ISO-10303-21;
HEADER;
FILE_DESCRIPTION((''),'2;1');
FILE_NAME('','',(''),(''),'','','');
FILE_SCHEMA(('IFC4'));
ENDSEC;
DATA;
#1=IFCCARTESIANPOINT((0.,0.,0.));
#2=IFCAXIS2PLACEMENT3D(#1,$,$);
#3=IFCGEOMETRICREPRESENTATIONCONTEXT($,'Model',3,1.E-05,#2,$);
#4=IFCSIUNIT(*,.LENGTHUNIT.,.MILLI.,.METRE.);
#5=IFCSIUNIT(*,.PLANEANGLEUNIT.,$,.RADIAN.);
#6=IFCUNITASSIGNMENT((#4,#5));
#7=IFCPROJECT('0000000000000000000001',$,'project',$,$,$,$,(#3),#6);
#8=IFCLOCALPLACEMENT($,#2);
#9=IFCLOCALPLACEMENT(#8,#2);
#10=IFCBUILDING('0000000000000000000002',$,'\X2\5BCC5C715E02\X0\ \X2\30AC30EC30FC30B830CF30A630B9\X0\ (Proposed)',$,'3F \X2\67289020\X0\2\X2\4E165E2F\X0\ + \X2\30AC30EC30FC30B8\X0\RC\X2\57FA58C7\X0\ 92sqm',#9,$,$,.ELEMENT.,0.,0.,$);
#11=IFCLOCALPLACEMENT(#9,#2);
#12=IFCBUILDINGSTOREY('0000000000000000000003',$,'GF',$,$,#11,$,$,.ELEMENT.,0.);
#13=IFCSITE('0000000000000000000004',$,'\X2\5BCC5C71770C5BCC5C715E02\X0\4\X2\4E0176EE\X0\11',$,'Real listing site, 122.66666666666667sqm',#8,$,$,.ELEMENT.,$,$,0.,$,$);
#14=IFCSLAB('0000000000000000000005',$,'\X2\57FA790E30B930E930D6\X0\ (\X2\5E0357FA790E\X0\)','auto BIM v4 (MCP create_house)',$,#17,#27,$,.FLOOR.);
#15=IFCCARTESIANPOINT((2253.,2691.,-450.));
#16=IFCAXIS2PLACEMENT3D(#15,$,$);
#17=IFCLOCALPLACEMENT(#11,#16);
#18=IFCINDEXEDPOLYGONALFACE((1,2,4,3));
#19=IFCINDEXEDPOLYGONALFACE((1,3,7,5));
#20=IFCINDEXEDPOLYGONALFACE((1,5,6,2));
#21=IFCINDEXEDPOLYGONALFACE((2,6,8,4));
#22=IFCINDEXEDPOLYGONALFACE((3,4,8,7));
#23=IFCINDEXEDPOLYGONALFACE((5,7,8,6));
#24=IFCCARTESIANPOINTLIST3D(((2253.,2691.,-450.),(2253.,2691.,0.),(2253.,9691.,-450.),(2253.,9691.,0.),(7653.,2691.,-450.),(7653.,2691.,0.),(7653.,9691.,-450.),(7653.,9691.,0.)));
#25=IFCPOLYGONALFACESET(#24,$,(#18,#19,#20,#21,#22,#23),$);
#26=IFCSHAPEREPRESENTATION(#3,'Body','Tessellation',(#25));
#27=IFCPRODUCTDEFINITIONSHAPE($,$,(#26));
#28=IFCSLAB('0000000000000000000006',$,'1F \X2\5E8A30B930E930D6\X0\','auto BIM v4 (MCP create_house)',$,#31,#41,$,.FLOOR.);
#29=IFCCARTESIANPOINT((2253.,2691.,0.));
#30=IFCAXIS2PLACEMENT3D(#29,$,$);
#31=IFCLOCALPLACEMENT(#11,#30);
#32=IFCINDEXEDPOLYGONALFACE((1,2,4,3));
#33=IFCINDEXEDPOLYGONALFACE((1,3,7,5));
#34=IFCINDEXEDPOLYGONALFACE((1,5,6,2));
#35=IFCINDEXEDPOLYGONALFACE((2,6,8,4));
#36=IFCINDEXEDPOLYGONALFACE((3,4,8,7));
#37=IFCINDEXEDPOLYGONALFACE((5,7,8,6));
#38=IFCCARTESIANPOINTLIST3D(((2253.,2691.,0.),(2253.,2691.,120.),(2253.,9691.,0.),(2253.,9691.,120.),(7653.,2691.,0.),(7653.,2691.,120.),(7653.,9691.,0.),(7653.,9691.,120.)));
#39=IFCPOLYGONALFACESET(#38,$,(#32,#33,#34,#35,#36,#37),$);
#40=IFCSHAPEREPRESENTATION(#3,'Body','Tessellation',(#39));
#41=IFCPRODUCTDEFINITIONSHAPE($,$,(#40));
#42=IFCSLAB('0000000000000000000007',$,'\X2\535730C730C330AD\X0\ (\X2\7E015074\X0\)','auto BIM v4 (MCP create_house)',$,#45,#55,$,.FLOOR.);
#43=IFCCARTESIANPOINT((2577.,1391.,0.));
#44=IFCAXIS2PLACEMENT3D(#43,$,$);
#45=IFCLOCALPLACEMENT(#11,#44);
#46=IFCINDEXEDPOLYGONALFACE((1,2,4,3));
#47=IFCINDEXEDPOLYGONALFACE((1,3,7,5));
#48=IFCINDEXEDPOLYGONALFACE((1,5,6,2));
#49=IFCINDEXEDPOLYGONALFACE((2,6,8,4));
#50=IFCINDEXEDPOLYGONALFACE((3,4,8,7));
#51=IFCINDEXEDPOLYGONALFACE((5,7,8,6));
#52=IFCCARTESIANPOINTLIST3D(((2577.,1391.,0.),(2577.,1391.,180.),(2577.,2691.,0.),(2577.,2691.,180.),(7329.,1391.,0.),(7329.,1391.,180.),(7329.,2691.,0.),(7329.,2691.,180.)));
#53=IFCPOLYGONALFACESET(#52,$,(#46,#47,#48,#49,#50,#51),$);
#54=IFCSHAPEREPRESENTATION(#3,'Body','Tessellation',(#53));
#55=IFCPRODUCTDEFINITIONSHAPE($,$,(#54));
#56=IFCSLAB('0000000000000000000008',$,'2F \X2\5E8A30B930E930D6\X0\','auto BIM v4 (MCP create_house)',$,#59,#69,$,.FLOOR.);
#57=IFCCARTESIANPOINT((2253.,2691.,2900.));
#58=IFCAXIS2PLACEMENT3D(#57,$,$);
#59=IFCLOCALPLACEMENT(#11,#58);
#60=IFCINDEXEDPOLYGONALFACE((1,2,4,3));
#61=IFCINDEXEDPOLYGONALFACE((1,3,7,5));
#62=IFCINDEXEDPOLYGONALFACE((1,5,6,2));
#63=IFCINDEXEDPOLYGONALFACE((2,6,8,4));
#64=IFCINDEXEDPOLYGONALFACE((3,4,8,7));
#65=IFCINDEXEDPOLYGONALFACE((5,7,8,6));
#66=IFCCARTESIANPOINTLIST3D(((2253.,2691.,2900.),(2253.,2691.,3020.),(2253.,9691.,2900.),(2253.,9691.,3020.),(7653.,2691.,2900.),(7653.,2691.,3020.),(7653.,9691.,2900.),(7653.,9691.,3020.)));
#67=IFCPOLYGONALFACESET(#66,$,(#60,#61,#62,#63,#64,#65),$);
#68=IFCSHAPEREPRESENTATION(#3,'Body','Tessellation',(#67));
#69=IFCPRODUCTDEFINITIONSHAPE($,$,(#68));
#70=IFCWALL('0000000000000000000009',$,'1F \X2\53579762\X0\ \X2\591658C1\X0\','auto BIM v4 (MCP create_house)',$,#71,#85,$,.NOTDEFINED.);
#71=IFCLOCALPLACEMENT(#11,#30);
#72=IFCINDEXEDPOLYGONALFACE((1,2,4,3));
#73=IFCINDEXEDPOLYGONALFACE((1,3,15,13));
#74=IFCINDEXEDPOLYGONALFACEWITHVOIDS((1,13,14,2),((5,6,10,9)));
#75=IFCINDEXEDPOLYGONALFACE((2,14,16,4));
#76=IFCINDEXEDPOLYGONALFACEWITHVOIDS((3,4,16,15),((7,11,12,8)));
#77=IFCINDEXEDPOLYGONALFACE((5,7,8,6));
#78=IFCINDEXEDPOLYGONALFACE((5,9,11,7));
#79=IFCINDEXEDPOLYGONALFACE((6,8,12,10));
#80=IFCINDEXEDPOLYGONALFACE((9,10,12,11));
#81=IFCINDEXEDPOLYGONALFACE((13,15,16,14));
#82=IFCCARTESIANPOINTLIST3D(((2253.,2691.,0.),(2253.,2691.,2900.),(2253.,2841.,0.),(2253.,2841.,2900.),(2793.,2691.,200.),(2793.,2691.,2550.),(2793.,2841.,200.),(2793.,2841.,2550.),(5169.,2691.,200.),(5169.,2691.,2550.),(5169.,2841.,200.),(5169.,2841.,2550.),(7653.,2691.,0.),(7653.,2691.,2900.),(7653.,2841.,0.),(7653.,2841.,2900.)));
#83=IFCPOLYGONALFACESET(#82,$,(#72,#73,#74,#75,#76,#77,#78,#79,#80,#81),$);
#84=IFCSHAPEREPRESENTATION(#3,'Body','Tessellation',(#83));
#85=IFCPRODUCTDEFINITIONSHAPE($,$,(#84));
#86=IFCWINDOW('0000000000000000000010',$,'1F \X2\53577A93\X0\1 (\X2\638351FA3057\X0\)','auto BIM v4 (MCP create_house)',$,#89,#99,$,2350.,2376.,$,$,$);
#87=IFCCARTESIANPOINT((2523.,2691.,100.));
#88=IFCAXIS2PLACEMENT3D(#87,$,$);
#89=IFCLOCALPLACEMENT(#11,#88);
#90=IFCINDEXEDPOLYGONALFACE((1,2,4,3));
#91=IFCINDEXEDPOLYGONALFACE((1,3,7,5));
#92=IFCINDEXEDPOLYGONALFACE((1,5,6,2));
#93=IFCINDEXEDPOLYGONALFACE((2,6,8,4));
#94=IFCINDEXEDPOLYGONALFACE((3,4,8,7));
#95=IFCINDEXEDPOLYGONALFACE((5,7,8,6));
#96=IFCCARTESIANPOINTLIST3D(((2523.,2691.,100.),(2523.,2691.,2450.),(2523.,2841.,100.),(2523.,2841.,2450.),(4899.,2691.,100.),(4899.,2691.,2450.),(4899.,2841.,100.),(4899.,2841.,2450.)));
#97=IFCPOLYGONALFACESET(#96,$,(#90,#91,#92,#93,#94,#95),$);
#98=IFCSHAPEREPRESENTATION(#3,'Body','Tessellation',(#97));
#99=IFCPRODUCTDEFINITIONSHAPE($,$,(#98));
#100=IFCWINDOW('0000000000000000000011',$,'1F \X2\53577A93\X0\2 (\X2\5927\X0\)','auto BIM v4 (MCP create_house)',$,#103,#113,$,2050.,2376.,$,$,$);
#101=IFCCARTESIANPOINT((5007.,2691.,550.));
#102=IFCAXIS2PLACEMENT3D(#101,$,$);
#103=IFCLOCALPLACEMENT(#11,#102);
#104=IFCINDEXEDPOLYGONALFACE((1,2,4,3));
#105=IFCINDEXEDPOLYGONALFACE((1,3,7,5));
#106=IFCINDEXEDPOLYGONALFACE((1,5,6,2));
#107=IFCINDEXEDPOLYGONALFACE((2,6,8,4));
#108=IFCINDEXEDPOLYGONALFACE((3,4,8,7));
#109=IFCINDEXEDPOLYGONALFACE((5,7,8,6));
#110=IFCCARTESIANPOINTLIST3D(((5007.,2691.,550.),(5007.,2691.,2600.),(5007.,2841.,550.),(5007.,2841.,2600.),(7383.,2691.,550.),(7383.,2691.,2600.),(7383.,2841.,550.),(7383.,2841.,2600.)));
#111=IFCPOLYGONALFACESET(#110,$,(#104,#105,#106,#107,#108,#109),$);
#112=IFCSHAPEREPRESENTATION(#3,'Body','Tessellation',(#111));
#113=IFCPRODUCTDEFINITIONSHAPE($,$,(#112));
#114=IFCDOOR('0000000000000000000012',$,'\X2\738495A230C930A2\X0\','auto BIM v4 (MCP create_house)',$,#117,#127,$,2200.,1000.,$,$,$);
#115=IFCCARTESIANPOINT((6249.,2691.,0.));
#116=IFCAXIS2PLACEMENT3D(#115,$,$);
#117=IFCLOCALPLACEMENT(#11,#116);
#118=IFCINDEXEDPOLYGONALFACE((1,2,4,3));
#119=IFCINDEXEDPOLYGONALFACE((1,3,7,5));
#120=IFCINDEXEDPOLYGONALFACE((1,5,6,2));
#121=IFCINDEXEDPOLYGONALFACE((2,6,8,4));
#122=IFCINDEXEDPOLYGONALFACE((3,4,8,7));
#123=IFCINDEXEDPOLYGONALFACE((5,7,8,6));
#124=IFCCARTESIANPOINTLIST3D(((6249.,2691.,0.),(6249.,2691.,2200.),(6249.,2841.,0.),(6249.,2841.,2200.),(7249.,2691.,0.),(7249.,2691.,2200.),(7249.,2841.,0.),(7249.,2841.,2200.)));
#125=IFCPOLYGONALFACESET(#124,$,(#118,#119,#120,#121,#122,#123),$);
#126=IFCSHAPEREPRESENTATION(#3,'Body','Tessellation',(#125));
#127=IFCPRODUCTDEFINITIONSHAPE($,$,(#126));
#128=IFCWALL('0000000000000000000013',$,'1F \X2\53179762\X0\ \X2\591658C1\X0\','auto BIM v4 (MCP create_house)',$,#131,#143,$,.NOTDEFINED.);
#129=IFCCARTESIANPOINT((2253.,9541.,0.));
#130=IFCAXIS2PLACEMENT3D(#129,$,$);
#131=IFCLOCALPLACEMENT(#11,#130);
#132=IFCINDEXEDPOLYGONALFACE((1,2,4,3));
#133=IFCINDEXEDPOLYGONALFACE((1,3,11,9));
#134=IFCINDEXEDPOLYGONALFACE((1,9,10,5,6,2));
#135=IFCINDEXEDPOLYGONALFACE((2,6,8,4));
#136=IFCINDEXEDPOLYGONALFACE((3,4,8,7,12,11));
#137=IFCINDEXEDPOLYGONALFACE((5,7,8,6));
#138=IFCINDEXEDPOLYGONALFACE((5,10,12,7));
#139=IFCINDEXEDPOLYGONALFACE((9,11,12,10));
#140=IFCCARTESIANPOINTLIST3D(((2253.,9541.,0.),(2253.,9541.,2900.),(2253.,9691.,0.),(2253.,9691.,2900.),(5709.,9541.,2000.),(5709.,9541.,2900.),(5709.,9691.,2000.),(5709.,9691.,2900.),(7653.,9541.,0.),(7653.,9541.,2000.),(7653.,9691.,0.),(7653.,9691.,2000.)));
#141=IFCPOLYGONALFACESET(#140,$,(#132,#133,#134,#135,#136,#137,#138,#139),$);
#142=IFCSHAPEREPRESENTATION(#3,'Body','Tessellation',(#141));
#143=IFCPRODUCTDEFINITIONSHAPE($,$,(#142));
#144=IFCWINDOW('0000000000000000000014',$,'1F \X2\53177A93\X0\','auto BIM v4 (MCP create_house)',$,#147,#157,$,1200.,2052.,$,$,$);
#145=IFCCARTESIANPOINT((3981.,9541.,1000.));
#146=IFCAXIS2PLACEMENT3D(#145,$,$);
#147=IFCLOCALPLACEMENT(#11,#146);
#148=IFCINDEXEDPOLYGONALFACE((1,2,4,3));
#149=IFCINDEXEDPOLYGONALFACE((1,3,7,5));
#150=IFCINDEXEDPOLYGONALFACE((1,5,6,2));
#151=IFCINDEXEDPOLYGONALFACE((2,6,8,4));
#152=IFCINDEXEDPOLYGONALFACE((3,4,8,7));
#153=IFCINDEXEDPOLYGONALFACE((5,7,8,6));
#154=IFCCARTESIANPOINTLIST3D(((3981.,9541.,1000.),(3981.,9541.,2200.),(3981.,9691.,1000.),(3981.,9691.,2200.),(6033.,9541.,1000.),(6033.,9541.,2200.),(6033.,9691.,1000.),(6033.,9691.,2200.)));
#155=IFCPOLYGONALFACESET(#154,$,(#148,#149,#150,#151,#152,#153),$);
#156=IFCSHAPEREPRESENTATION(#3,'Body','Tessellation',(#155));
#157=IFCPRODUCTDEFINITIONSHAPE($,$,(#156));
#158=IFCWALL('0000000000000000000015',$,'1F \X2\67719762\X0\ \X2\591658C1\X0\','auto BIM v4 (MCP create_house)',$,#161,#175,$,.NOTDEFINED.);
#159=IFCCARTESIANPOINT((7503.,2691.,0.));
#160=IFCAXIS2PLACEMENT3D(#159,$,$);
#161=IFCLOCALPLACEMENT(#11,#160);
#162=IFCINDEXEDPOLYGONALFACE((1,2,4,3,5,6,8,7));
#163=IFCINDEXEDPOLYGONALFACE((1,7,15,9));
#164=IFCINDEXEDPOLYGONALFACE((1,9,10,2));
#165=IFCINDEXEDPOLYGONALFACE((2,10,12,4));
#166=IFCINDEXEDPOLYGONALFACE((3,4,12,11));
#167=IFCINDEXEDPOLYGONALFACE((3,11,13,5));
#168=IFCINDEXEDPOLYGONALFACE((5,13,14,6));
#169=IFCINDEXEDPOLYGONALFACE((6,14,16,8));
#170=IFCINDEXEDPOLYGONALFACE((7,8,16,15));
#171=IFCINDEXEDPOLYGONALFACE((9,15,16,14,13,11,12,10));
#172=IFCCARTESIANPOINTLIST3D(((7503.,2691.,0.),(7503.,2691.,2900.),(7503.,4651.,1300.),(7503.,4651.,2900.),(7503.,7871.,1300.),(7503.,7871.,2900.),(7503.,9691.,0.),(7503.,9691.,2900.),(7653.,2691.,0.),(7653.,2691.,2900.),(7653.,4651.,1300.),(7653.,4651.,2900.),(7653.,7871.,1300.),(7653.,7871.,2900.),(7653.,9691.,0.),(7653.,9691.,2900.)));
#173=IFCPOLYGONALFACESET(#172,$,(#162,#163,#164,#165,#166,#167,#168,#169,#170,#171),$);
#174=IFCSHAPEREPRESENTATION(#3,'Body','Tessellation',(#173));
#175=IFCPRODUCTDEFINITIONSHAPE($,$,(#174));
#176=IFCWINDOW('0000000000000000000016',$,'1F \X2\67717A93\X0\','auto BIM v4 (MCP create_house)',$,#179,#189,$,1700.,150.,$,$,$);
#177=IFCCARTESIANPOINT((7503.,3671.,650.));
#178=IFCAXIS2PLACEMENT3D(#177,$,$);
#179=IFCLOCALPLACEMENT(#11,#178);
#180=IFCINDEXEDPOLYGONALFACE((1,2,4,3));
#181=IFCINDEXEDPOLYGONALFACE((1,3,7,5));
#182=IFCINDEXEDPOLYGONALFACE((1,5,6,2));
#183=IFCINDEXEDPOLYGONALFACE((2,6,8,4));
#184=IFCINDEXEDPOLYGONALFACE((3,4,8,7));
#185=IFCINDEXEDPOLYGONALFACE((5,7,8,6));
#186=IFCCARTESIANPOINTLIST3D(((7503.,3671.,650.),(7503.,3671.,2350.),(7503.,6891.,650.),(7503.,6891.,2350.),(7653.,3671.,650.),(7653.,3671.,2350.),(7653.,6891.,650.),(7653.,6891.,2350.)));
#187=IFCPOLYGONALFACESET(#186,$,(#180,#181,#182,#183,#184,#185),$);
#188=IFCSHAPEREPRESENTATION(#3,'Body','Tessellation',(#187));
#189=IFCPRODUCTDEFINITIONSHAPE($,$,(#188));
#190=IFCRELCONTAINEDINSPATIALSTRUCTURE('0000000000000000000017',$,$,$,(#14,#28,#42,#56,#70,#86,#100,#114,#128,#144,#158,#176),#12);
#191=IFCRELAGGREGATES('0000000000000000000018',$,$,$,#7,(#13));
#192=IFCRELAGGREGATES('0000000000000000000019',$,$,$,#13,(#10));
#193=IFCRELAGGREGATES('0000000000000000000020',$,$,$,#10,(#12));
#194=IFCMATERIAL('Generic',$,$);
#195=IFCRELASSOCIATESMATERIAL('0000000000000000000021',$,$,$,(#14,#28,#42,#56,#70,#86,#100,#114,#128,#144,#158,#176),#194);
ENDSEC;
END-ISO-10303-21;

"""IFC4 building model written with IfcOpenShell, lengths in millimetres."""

from ifc_helpers import new_model, si_unit, frame, frame_2d, origin, place, context, project, spatial, rectangle, extrude, material, element, fill, save


model = new_model("IFC4")

# Units and contexts
model_context = context("Model", 3, precision=1e-05, world=origin())
ifc_project = project(units=[si_unit("LENGTHUNIT", "METRE", prefix="MILLI"), si_unit("PLANEANGLEUNIT", "RADIAN")], contexts=[model_context])

# Site, building, storey
site_placement = place(None, origin())
site = spatial("IfcSite", under=ifc_project, at=site_placement, Name="富山県富山市4丁目11", ObjectType="Real listing site, 122.66666666666667sqm", CompositionType="ELEMENT", RefElevation=0.0)
building_placement = place(site_placement, origin())
building = spatial("IfcBuilding", under=site, at=building_placement, Name="富山市 ガレージハウス (Proposed)", ObjectType="3F 木造2世帯 + ガレージRC基壇 92sqm", CompositionType="ELEMENT", ElevationOfRefHeight=0.0, ElevationOfTerrain=0.0)
storey_placement = place(building_placement, origin())
storey = spatial("IfcBuildingStorey", under=building, at=storey_placement, Name="GF", CompositionType="ELEMENT", Elevation=0.0)

# Slabs
ifc_material = material(Name="Generic")
slab_1_placement = place(storey_placement, frame((2253.0, 2691.0, -450.0)))
element("IfcSlab", 1, at=slab_1_placement, inside=storey, material=ifc_material, Name="基礎スラブ (布基礎)", Description="auto BIM v4 (MCP create_house)", PredefinedType="FLOOR", context=model_context, shape_type="SweptSolid", body=[
    extrude(rectangle(XDim=5400.0, YDim=7000.0, at=frame_2d((2700.0, 3500.0))), frame((2253.0, 2691.0, -450.0)), (0.0, 0.0, 1.0), 450.0),
])
slab_2_placement = place(storey_placement, frame((2253.0, 2691.0, 0.0)))
element("IfcSlab", 2, at=slab_2_placement, inside=storey, material=ifc_material, Name="1F 床スラブ", Description="auto BIM v4 (MCP create_house)", PredefinedType="FLOOR", context=model_context, shape_type="SweptSolid", body=[
    extrude(rectangle(XDim=5400.0, YDim=7000.0, at=frame_2d((2700.0, 3500.0))), frame((2253.0, 2691.0, 0.0)), (0.0, 0.0, 1.0), 120.0),
])
slab_3_placement = place(storey_placement, frame((2577.0, 1391.0, 0.0)))
element("IfcSlab", 3, at=slab_3_placement, inside=storey, material=ifc_material, Name="南デッキ (縁側)", Description="auto BIM v4 (MCP create_house)", PredefinedType="FLOOR", context=model_context, shape_type="SweptSolid", body=[
    extrude(rectangle(XDim=4752.0, YDim=1300.0, at=frame_2d((2376.0, 650.0))), frame((2577.0, 1391.0, 0.0)), (0.0, 0.0, 1.0), 180.0),
])
slab_4_placement = place(storey_placement, frame((2253.0, 2691.0, 2900.0)))
element("IfcSlab", 4, at=slab_4_placement, inside=storey, material=ifc_material, Name="2F 床スラブ", Description="auto BIM v4 (MCP create_house)", PredefinedType="FLOOR", context=model_context, shape_type="SweptSolid", body=[
    extrude(rectangle(XDim=5400.0, YDim=7000.0, at=frame_2d((2700.0, 3500.0))), frame((2253.0, 2691.0, 2900.0)), (0.0, 0.0, 1.0), 120.0),
])

# Wall, openings, windows, door
wall_1_placement = place(storey_placement, frame((2253.0, 2691.0, 0.0)))
wall_1 = element("IfcWall", 5, at=wall_1_placement, inside=storey, material=ifc_material, Name="1F 南面 外壁", Description="auto BIM v4 (MCP create_house)", PredefinedType="NOTDEFINED", context=model_context, shape_type="SweptSolid", body=[
    extrude(rectangle(XDim=5400.0, YDim=150.0, at=frame_2d((2700.0, 75.0))), frame((2253.0, 2691.0, 0.0)), (0.0, 0.0, 1.0), 2900.0),
])
opening_1_placement = place(storey_placement, frame((2523.0, 2691.0, 100.0)))
opening_1 = element("IfcOpeningElement", 6, at=opening_1_placement, cuts=wall_1, PredefinedType="NOTDEFINED", context=model_context, shape_type="SweptSolid", body=[
    extrude(rectangle(XDim=2376.0, YDim=150.0, at=frame_2d((1188.0, 75.0))), frame((2523.0, 2691.0, 100.0)), (0.0, 0.0, 1.0), 2350.0),
])
opening_2_placement = place(storey_placement, frame((5007.0, 2691.0, 550.0)))
opening_2 = element("IfcOpeningElement", 7, at=opening_2_placement, cuts=wall_1, PredefinedType="NOTDEFINED", context=model_context, shape_type="SweptSolid", body=[
    extrude(rectangle(XDim=2376.0, YDim=150.0, at=frame_2d((1188.0, 75.0))), frame((5007.0, 2691.0, 550.0)), (0.0, 0.0, 1.0), 2050.0),
])
opening_3_placement = place(storey_placement, frame((6249.0, 2691.0, 0.0)))
opening_3 = element("IfcOpeningElement", 8, at=opening_3_placement, cuts=wall_1, PredefinedType="NOTDEFINED", context=model_context, shape_type="SweptSolid", body=[
    extrude(rectangle(XDim=1000.0, YDim=150.0, at=frame_2d((500.0, 75.0))), frame((6249.0, 2691.0, 0.0)), (0.0, 0.0, 1.0), 2200.0),
])
window_1_placement = place(storey_placement, frame((2523.0, 2691.0, 100.0)))
window_1 = element("IfcWindow", 9, at=window_1_placement, inside=storey, material=ifc_material, Name="1F 南窓1 (掃出し)", Description="auto BIM v4 (MCP create_house)", OverallHeight=2350.0, OverallWidth=2376.0, context=model_context, shape_type="SweptSolid", body=[
    extrude(rectangle(XDim=2376.0, YDim=150.0, at=frame_2d((1188.0, 75.0))), frame((2523.0, 2691.0, 100.0)), (0.0, 0.0, 1.0), 2350.0),
])
fill(opening_1, window_1)
window_2_placement = place(storey_placement, frame((5007.0, 2691.0, 550.0)))
window_2 = element("IfcWindow", 10, at=window_2_placement, inside=storey, material=ifc_material, Name="1F 南窓2 (大)", Description="auto BIM v4 (MCP create_house)", OverallHeight=2050.0, OverallWidth=2376.0, context=model_context, shape_type="SweptSolid", body=[
    extrude(rectangle(XDim=2376.0, YDim=150.0, at=frame_2d((1188.0, 75.0))), frame((5007.0, 2691.0, 550.0)), (0.0, 0.0, 1.0), 2050.0),
])
fill(opening_2, window_2)
door_placement = place(storey_placement, frame((6249.0, 2691.0, 0.0)))
door = element("IfcDoor", 11, at=door_placement, inside=storey, material=ifc_material, Name="玄関ドア", Description="auto BIM v4 (MCP create_house)", OverallHeight=2200.0, OverallWidth=1000.0, context=model_context, shape_type="SweptSolid", body=[
    extrude(rectangle(XDim=1000.0, YDim=150.0, at=frame_2d((500.0, 75.0))), frame((6249.0, 2691.0, 0.0)), (0.0, 0.0, 1.0), 2200.0),
])
fill(opening_3, door)

# Walls, openings, windows
wall_2_placement = place(storey_placement, frame((2253.0, 9541.0, 0.0)))
wall_2 = element("IfcWall", 12, at=wall_2_placement, inside=storey, material=ifc_material, Name="1F 北面 外壁", Description="auto BIM v4 (MCP create_house)", PredefinedType="NOTDEFINED", context=model_context, shape_type="SweptSolid", body=[
    extrude(rectangle(XDim=5400.0, YDim=150.0, at=frame_2d((2700.0, 75.0))), frame((2253.0, 9541.0, 0.0)), (0.0, 0.0, 1.0), 2900.0),
])
opening_4_placement = place(storey_placement, frame((3981.0, 9541.0, 1000.0)))
opening_4 = element("IfcOpeningElement", 13, at=opening_4_placement, cuts=wall_2, PredefinedType="NOTDEFINED", context=model_context, shape_type="SweptSolid", body=[
    extrude(rectangle(XDim=2052.0, YDim=150.0, at=frame_2d((1026.0, 75.0))), frame((3981.0, 9541.0, 1000.0)), (0.0, 0.0, 1.0), 1200.0),
])
window_3_placement = place(storey_placement, frame((3981.0, 9541.0, 1000.0)))
window_3 = element("IfcWindow", 14, at=window_3_placement, inside=storey, material=ifc_material, Name="1F 北窓", Description="auto BIM v4 (MCP create_house)", OverallHeight=1200.0, OverallWidth=2052.0, context=model_context, shape_type="SweptSolid", body=[
    extrude(rectangle(XDim=2052.0, YDim=150.0, at=frame_2d((1026.0, 75.0))), frame((3981.0, 9541.0, 1000.0)), (0.0, 0.0, 1.0), 1200.0),
])
fill(opening_4, window_3)
wall_3_placement = place(storey_placement, frame((7503.0, 2691.0, 0.0)))
wall_3 = element("IfcWall", 15, at=wall_3_placement, inside=storey, material=ifc_material, Name="1F 東面 外壁", Description="auto BIM v4 (MCP create_house)", PredefinedType="NOTDEFINED", context=model_context, shape_type="SweptSolid", body=[
    extrude(rectangle(XDim=150.0, YDim=7000.0, at=frame_2d((75.0, 3500.0))), frame((7503.0, 2691.0, 0.0)), (0.0, 0.0, 1.0), 2900.0),
])
opening_5_placement = place(storey_placement, frame((7503.0, 3671.0, 650.0)))
opening_5 = element("IfcOpeningElement", 16, at=opening_5_placement, cuts=wall_3, PredefinedType="NOTDEFINED", context=model_context, shape_type="SweptSolid", body=[
    extrude(rectangle(XDim=150.0, YDim=3220.0, at=frame_2d((75.0, 1610.0))), frame((7503.0, 3671.0, 650.0)), (0.0, 0.0, 1.0), 1700.0),
])
window_4_placement = place(storey_placement, frame((7503.0, 3671.0, 650.0)))
window_4 = element("IfcWindow", 17, at=window_4_placement, inside=storey, material=ifc_material, Name="1F 東窓", Description="auto BIM v4 (MCP create_house)", OverallHeight=1700.0, OverallWidth=150.0, context=model_context, shape_type="SweptSolid", body=[
    extrude(rectangle(XDim=150.0, YDim=3220.0, at=frame_2d((75.0, 1610.0))), frame((7503.0, 3671.0, 650.0)), (0.0, 0.0, 1.0), 1700.0),
])
fill(opening_5, window_4)

save(model, "model.ifc")
